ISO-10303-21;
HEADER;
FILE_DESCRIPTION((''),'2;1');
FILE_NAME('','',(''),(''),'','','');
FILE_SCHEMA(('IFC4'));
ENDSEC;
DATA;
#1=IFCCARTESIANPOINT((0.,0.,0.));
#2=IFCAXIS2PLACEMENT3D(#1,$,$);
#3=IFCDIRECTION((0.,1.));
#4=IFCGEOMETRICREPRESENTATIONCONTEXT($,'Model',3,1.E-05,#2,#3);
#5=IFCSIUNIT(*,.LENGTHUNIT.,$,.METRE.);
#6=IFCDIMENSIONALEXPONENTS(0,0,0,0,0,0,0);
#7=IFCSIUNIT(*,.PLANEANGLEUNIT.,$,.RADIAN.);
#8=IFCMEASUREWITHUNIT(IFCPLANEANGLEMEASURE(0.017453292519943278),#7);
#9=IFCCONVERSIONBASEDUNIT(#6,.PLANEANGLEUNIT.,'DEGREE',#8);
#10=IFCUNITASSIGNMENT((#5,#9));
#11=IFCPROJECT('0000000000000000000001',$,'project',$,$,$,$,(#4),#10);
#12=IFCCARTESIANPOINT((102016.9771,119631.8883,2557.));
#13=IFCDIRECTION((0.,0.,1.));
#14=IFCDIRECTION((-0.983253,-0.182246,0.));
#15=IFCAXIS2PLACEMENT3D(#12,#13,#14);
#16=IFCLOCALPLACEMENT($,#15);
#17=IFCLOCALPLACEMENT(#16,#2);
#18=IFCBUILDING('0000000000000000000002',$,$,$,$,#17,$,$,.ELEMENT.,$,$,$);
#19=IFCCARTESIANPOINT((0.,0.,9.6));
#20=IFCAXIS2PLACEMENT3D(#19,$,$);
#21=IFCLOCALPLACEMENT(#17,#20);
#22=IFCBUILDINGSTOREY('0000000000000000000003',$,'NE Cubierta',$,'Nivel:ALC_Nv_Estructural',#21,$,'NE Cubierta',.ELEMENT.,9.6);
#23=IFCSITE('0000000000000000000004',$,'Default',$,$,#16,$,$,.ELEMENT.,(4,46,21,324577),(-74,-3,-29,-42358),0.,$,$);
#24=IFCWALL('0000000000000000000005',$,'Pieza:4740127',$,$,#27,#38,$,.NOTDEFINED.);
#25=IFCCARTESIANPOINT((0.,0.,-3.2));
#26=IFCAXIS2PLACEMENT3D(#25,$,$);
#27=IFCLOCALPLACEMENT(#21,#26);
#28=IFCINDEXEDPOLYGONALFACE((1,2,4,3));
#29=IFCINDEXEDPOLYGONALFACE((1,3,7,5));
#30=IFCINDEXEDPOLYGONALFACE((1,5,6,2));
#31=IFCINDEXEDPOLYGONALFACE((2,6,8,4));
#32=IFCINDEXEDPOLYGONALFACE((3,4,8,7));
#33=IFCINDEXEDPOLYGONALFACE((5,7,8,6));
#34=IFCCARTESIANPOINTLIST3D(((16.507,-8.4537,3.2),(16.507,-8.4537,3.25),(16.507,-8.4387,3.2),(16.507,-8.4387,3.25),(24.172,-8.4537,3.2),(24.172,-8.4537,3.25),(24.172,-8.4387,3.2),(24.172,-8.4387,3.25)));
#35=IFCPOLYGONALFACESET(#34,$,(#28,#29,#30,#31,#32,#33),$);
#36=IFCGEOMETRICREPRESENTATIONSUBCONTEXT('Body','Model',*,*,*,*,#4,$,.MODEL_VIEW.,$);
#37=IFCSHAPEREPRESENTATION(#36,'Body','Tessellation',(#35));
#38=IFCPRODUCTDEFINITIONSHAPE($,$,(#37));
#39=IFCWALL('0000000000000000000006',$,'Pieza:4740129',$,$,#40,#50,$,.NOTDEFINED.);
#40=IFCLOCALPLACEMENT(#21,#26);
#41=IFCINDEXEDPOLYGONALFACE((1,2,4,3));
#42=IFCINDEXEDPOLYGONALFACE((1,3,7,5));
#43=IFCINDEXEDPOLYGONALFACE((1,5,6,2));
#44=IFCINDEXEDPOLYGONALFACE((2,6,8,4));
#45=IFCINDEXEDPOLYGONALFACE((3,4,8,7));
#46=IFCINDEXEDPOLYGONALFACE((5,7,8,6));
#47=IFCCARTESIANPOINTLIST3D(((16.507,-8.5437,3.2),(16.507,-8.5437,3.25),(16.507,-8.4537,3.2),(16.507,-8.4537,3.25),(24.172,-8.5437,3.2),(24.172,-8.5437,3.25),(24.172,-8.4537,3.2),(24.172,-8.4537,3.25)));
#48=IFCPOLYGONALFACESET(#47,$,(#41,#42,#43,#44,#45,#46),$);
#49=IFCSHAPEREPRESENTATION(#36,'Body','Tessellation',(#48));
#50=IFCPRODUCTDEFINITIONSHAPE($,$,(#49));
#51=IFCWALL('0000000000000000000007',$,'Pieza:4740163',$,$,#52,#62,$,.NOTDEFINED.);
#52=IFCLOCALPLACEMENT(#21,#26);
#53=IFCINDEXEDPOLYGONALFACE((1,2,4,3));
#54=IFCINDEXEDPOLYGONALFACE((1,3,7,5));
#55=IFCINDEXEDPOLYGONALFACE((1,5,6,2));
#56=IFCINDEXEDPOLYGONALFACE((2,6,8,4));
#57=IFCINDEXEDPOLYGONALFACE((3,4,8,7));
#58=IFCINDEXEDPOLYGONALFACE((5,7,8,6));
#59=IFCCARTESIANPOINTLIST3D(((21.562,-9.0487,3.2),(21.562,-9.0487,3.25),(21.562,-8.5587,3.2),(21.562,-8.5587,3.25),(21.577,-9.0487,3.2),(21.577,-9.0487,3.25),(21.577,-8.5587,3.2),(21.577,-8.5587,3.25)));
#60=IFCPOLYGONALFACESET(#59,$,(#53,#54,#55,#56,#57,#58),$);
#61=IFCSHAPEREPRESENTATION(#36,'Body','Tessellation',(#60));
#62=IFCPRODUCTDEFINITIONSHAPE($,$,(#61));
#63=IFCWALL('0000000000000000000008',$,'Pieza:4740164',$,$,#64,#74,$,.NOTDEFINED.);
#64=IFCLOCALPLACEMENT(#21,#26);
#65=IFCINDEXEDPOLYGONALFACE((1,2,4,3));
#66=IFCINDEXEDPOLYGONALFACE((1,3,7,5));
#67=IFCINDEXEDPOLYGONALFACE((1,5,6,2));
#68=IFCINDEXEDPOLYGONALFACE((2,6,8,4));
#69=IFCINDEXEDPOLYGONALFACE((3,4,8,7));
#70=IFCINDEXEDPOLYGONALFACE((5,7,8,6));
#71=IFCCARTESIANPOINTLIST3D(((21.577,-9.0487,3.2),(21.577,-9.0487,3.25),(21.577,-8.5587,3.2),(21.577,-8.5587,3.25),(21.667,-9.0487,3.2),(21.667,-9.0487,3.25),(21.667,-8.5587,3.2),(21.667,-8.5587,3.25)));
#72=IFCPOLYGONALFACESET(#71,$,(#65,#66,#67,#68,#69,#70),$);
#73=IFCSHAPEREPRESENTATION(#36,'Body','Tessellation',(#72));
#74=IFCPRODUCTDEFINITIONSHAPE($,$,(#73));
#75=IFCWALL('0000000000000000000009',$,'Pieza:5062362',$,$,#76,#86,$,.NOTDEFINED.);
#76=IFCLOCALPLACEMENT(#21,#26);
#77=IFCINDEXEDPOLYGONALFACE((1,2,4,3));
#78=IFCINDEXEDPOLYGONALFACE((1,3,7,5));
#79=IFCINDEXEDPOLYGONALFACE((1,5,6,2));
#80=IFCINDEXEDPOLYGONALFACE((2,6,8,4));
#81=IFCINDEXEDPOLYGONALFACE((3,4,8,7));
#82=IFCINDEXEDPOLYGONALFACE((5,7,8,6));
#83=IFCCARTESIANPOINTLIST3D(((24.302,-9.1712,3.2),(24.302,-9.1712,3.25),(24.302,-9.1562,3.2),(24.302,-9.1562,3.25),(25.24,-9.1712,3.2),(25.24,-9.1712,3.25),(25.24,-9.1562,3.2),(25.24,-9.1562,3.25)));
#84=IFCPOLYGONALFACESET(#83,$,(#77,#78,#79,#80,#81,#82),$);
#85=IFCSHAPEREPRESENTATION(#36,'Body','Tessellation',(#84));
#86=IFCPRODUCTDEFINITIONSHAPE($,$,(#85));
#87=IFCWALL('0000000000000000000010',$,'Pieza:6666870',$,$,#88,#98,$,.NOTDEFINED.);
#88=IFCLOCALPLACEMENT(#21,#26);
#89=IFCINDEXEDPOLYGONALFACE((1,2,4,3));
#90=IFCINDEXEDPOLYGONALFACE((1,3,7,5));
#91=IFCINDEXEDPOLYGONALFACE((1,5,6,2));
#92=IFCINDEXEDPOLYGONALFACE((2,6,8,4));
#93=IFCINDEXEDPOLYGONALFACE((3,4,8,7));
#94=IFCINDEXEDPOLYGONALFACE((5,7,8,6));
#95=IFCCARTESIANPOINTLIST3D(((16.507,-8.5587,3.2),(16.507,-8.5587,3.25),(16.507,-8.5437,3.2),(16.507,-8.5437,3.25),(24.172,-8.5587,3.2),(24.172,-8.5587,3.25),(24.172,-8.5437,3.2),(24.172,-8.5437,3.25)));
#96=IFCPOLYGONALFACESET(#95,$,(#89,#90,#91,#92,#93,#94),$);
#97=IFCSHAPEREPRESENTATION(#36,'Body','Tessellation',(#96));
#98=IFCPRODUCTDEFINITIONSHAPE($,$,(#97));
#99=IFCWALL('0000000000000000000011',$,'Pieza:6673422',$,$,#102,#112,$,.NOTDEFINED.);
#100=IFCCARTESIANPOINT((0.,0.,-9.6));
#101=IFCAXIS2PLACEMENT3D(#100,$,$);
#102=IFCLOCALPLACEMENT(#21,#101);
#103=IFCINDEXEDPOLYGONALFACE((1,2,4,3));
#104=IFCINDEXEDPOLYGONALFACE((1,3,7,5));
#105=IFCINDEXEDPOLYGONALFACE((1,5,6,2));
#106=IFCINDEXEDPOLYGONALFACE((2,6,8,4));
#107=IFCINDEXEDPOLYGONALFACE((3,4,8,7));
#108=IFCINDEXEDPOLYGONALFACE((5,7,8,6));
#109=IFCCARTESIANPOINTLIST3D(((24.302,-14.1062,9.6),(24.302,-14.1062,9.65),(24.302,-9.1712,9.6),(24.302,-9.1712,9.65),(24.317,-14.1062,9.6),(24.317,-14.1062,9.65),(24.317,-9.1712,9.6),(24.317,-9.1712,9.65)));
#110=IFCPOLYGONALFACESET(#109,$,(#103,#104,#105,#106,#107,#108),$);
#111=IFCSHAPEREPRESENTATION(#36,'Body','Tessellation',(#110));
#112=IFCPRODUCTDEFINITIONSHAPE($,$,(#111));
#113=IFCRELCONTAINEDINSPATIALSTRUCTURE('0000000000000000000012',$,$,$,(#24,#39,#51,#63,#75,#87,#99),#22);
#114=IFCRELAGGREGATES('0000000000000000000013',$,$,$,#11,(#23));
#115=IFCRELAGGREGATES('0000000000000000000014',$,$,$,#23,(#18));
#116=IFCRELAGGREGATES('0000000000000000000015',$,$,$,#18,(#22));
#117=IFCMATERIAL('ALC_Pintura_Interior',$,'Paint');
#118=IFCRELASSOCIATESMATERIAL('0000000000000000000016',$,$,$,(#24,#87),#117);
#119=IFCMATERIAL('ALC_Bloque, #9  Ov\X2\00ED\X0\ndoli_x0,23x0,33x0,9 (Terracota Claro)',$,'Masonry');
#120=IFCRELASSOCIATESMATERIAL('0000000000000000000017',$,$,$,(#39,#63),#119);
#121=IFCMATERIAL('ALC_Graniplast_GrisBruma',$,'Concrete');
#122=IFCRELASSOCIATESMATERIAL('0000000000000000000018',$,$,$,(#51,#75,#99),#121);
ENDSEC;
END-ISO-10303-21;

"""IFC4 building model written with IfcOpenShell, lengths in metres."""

from ifc_helpers import new_model, entity, si_unit, converted_unit, direction, frame, frame_2d, origin, place, context, subcontext, project, spatial, rectangle, extrude, material, element, save


model = new_model("IFC4")

# Units and contexts
model_context = context("Model", 3, precision=1e-05, world=origin(), true_north=direction((0.0, 1.0)))
body_context = subcontext(model_context, "Body", "Model", "MODEL_VIEW")
ifc_project = project(units=[si_unit("LENGTHUNIT", "METRE"), converted_unit("PLANEANGLEUNIT", "DEGREE", entity("IfcPlaneAngleMeasure", 0.017453292519943278), si_unit("PLANEANGLEUNIT", "RADIAN"), dimensions=[0, 0, 0, 0, 0, 0, 0])], contexts=[model_context])

# Site, building, storey
site_placement = place(None, frame((102016.9771, 119631.8883, 2557.0), z_axis=(0.0, 0.0, 1.0), x_axis=(-0.983253, -0.182246, 0.0)))
site = spatial("IfcSite", under=ifc_project, at=site_placement, Name="Default", CompositionType="ELEMENT", RefLatitude=(4, 46, 21, 324577), RefLongitude=(-74, -3, -29, -42358), RefElevation=0.0)
building_placement = place(site_placement, origin())
building = spatial("IfcBuilding", under=site, at=building_placement, CompositionType="ELEMENT")
storey_placement = place(building_placement, frame((0.0, 0.0, 9.6)))
storey = spatial("IfcBuildingStorey", under=building, at=storey_placement, Name="NE Cubierta", ObjectType="Nivel:ALC_Nv_Estructural", LongName="NE Cubierta", CompositionType="ELEMENT", Elevation=9.6)

# Walls
ifc_material_1 = material(Name="ALC_Pintura_Interior", Category="Paint")
wall_1_placement = place(storey_placement, frame((0.0, 0.0, -3.2)))
element("IfcWall", 1, at=wall_1_placement, inside=storey, material=ifc_material_1, Name="Pieza:4740127", PredefinedType="NOTDEFINED", context=body_context, shape_type="SweptSolid", body=[
    extrude(rectangle(XDim=0.015, YDim=7.665, at=frame_2d((0.0, 0.0), x_axis=(1.0, 0.0))), frame((20.3395, -8.4462, 3.2), z_axis=(0.0, 0.0, 1.0), x_axis=(0.0, -1.0, 0.0)), (0.0, 0.0, 1.0), 0.05),
])
ifc_material_2 = material(Name="ALC_Bloque, #9  Ovíndoli_x0,23x0,33x0,9 (Terracota Claro)", Category="Masonry")
wall_2_placement = place(storey_placement, frame((0.0, 0.0, -3.2)))
element("IfcWall", 2, at=wall_2_placement, inside=storey, material=ifc_material_2, Name="Pieza:4740129", PredefinedType="NOTDEFINED", context=body_context, shape_type="SweptSolid", body=[
    extrude(rectangle(XDim=0.09, YDim=7.665, at=frame_2d((0.0, 0.0), x_axis=(1.0, 0.0))), frame((20.3395, -8.4987, 3.2), z_axis=(0.0, 0.0, 1.0), x_axis=(0.0, -1.0, 0.0)), (0.0, 0.0, 1.0), 0.05),
])
ifc_material_3 = material(Name="ALC_Graniplast_GrisBruma", Category="Concrete")
wall_3_placement = place(storey_placement, frame((0.0, 0.0, -3.2)))
element("IfcWall", 3, at=wall_3_placement, inside=storey, material=ifc_material_3, Name="Pieza:4740163", PredefinedType="NOTDEFINED", context=body_context, shape_type="SweptSolid", body=[
    extrude(rectangle(XDim=0.49, YDim=0.015, at=frame_2d((0.0, 0.0), x_axis=(1.0, 0.0))), frame((21.5695, -8.8037, 3.2), z_axis=(0.0, 0.0, 1.0), x_axis=(0.0, -1.0, 0.0)), (0.0, 0.0, 1.0), 0.05),
])
wall_4_placement = place(storey_placement, frame((0.0, 0.0, -3.2)))
element("IfcWall", 4, at=wall_4_placement, inside=storey, material=ifc_material_2, Name="Pieza:4740164", PredefinedType="NOTDEFINED", context=body_context, shape_type="SweptSolid", body=[
    extrude(rectangle(XDim=0.49, YDim=0.09, at=frame_2d((0.0, 0.0), x_axis=(1.0, 0.0))), frame((21.622, -8.8037, 3.2), z_axis=(0.0, 0.0, 1.0), x_axis=(0.0, -1.0, 0.0)), (0.0, 0.0, 1.0), 0.05),
])
wall_5_placement = place(storey_placement, frame((0.0, 0.0, -3.2)))
element("IfcWall", 5, at=wall_5_placement, inside=storey, material=ifc_material_3, Name="Pieza:5062362", PredefinedType="NOTDEFINED", context=body_context, shape_type="SweptSolid", body=[
    extrude(rectangle(XDim=0.015, YDim=0.938, at=frame_2d((0.0, 0.0), x_axis=(1.0, 0.0))), frame((24.771, -9.1637, 3.2), z_axis=(0.0, 0.0, 1.0), x_axis=(0.0, -1.0, 0.0)), (0.0, 0.0, 1.0), 0.05),
])
wall_6_placement = place(storey_placement, frame((0.0, 0.0, -3.2)))
element("IfcWall", 6, at=wall_6_placement, inside=storey, material=ifc_material_1, Name="Pieza:6666870", PredefinedType="NOTDEFINED", context=body_context, shape_type="SweptSolid", body=[
    extrude(rectangle(XDim=0.015, YDim=7.665, at=frame_2d((0.0, 0.0), x_axis=(1.0, 0.0))), frame((20.3395, -8.5512, 3.2), z_axis=(0.0, 0.0, 1.0), x_axis=(0.0, -1.0, 0.0)), (0.0, 0.0, 1.0), 0.05),
])
wall_7_placement = place(storey_placement, frame((0.0, 0.0, -9.6)))
element("IfcWall", 7, at=wall_7_placement, inside=storey, material=ifc_material_3, Name="Pieza:6673422", PredefinedType="NOTDEFINED", context=body_context, shape_type="SweptSolid", body=[
    extrude(rectangle(XDim=4.935, YDim=0.015, at=frame_2d((0.0, 0.0), x_axis=(1.0, 0.0))), frame((24.3095, -11.6387, 9.6), z_axis=(0.0, 0.0, 1.0), x_axis=(0.0, -1.0, 0.0)), (0.0, 0.0, 1.0), 0.05),
])

save(model, "model.ifc")
